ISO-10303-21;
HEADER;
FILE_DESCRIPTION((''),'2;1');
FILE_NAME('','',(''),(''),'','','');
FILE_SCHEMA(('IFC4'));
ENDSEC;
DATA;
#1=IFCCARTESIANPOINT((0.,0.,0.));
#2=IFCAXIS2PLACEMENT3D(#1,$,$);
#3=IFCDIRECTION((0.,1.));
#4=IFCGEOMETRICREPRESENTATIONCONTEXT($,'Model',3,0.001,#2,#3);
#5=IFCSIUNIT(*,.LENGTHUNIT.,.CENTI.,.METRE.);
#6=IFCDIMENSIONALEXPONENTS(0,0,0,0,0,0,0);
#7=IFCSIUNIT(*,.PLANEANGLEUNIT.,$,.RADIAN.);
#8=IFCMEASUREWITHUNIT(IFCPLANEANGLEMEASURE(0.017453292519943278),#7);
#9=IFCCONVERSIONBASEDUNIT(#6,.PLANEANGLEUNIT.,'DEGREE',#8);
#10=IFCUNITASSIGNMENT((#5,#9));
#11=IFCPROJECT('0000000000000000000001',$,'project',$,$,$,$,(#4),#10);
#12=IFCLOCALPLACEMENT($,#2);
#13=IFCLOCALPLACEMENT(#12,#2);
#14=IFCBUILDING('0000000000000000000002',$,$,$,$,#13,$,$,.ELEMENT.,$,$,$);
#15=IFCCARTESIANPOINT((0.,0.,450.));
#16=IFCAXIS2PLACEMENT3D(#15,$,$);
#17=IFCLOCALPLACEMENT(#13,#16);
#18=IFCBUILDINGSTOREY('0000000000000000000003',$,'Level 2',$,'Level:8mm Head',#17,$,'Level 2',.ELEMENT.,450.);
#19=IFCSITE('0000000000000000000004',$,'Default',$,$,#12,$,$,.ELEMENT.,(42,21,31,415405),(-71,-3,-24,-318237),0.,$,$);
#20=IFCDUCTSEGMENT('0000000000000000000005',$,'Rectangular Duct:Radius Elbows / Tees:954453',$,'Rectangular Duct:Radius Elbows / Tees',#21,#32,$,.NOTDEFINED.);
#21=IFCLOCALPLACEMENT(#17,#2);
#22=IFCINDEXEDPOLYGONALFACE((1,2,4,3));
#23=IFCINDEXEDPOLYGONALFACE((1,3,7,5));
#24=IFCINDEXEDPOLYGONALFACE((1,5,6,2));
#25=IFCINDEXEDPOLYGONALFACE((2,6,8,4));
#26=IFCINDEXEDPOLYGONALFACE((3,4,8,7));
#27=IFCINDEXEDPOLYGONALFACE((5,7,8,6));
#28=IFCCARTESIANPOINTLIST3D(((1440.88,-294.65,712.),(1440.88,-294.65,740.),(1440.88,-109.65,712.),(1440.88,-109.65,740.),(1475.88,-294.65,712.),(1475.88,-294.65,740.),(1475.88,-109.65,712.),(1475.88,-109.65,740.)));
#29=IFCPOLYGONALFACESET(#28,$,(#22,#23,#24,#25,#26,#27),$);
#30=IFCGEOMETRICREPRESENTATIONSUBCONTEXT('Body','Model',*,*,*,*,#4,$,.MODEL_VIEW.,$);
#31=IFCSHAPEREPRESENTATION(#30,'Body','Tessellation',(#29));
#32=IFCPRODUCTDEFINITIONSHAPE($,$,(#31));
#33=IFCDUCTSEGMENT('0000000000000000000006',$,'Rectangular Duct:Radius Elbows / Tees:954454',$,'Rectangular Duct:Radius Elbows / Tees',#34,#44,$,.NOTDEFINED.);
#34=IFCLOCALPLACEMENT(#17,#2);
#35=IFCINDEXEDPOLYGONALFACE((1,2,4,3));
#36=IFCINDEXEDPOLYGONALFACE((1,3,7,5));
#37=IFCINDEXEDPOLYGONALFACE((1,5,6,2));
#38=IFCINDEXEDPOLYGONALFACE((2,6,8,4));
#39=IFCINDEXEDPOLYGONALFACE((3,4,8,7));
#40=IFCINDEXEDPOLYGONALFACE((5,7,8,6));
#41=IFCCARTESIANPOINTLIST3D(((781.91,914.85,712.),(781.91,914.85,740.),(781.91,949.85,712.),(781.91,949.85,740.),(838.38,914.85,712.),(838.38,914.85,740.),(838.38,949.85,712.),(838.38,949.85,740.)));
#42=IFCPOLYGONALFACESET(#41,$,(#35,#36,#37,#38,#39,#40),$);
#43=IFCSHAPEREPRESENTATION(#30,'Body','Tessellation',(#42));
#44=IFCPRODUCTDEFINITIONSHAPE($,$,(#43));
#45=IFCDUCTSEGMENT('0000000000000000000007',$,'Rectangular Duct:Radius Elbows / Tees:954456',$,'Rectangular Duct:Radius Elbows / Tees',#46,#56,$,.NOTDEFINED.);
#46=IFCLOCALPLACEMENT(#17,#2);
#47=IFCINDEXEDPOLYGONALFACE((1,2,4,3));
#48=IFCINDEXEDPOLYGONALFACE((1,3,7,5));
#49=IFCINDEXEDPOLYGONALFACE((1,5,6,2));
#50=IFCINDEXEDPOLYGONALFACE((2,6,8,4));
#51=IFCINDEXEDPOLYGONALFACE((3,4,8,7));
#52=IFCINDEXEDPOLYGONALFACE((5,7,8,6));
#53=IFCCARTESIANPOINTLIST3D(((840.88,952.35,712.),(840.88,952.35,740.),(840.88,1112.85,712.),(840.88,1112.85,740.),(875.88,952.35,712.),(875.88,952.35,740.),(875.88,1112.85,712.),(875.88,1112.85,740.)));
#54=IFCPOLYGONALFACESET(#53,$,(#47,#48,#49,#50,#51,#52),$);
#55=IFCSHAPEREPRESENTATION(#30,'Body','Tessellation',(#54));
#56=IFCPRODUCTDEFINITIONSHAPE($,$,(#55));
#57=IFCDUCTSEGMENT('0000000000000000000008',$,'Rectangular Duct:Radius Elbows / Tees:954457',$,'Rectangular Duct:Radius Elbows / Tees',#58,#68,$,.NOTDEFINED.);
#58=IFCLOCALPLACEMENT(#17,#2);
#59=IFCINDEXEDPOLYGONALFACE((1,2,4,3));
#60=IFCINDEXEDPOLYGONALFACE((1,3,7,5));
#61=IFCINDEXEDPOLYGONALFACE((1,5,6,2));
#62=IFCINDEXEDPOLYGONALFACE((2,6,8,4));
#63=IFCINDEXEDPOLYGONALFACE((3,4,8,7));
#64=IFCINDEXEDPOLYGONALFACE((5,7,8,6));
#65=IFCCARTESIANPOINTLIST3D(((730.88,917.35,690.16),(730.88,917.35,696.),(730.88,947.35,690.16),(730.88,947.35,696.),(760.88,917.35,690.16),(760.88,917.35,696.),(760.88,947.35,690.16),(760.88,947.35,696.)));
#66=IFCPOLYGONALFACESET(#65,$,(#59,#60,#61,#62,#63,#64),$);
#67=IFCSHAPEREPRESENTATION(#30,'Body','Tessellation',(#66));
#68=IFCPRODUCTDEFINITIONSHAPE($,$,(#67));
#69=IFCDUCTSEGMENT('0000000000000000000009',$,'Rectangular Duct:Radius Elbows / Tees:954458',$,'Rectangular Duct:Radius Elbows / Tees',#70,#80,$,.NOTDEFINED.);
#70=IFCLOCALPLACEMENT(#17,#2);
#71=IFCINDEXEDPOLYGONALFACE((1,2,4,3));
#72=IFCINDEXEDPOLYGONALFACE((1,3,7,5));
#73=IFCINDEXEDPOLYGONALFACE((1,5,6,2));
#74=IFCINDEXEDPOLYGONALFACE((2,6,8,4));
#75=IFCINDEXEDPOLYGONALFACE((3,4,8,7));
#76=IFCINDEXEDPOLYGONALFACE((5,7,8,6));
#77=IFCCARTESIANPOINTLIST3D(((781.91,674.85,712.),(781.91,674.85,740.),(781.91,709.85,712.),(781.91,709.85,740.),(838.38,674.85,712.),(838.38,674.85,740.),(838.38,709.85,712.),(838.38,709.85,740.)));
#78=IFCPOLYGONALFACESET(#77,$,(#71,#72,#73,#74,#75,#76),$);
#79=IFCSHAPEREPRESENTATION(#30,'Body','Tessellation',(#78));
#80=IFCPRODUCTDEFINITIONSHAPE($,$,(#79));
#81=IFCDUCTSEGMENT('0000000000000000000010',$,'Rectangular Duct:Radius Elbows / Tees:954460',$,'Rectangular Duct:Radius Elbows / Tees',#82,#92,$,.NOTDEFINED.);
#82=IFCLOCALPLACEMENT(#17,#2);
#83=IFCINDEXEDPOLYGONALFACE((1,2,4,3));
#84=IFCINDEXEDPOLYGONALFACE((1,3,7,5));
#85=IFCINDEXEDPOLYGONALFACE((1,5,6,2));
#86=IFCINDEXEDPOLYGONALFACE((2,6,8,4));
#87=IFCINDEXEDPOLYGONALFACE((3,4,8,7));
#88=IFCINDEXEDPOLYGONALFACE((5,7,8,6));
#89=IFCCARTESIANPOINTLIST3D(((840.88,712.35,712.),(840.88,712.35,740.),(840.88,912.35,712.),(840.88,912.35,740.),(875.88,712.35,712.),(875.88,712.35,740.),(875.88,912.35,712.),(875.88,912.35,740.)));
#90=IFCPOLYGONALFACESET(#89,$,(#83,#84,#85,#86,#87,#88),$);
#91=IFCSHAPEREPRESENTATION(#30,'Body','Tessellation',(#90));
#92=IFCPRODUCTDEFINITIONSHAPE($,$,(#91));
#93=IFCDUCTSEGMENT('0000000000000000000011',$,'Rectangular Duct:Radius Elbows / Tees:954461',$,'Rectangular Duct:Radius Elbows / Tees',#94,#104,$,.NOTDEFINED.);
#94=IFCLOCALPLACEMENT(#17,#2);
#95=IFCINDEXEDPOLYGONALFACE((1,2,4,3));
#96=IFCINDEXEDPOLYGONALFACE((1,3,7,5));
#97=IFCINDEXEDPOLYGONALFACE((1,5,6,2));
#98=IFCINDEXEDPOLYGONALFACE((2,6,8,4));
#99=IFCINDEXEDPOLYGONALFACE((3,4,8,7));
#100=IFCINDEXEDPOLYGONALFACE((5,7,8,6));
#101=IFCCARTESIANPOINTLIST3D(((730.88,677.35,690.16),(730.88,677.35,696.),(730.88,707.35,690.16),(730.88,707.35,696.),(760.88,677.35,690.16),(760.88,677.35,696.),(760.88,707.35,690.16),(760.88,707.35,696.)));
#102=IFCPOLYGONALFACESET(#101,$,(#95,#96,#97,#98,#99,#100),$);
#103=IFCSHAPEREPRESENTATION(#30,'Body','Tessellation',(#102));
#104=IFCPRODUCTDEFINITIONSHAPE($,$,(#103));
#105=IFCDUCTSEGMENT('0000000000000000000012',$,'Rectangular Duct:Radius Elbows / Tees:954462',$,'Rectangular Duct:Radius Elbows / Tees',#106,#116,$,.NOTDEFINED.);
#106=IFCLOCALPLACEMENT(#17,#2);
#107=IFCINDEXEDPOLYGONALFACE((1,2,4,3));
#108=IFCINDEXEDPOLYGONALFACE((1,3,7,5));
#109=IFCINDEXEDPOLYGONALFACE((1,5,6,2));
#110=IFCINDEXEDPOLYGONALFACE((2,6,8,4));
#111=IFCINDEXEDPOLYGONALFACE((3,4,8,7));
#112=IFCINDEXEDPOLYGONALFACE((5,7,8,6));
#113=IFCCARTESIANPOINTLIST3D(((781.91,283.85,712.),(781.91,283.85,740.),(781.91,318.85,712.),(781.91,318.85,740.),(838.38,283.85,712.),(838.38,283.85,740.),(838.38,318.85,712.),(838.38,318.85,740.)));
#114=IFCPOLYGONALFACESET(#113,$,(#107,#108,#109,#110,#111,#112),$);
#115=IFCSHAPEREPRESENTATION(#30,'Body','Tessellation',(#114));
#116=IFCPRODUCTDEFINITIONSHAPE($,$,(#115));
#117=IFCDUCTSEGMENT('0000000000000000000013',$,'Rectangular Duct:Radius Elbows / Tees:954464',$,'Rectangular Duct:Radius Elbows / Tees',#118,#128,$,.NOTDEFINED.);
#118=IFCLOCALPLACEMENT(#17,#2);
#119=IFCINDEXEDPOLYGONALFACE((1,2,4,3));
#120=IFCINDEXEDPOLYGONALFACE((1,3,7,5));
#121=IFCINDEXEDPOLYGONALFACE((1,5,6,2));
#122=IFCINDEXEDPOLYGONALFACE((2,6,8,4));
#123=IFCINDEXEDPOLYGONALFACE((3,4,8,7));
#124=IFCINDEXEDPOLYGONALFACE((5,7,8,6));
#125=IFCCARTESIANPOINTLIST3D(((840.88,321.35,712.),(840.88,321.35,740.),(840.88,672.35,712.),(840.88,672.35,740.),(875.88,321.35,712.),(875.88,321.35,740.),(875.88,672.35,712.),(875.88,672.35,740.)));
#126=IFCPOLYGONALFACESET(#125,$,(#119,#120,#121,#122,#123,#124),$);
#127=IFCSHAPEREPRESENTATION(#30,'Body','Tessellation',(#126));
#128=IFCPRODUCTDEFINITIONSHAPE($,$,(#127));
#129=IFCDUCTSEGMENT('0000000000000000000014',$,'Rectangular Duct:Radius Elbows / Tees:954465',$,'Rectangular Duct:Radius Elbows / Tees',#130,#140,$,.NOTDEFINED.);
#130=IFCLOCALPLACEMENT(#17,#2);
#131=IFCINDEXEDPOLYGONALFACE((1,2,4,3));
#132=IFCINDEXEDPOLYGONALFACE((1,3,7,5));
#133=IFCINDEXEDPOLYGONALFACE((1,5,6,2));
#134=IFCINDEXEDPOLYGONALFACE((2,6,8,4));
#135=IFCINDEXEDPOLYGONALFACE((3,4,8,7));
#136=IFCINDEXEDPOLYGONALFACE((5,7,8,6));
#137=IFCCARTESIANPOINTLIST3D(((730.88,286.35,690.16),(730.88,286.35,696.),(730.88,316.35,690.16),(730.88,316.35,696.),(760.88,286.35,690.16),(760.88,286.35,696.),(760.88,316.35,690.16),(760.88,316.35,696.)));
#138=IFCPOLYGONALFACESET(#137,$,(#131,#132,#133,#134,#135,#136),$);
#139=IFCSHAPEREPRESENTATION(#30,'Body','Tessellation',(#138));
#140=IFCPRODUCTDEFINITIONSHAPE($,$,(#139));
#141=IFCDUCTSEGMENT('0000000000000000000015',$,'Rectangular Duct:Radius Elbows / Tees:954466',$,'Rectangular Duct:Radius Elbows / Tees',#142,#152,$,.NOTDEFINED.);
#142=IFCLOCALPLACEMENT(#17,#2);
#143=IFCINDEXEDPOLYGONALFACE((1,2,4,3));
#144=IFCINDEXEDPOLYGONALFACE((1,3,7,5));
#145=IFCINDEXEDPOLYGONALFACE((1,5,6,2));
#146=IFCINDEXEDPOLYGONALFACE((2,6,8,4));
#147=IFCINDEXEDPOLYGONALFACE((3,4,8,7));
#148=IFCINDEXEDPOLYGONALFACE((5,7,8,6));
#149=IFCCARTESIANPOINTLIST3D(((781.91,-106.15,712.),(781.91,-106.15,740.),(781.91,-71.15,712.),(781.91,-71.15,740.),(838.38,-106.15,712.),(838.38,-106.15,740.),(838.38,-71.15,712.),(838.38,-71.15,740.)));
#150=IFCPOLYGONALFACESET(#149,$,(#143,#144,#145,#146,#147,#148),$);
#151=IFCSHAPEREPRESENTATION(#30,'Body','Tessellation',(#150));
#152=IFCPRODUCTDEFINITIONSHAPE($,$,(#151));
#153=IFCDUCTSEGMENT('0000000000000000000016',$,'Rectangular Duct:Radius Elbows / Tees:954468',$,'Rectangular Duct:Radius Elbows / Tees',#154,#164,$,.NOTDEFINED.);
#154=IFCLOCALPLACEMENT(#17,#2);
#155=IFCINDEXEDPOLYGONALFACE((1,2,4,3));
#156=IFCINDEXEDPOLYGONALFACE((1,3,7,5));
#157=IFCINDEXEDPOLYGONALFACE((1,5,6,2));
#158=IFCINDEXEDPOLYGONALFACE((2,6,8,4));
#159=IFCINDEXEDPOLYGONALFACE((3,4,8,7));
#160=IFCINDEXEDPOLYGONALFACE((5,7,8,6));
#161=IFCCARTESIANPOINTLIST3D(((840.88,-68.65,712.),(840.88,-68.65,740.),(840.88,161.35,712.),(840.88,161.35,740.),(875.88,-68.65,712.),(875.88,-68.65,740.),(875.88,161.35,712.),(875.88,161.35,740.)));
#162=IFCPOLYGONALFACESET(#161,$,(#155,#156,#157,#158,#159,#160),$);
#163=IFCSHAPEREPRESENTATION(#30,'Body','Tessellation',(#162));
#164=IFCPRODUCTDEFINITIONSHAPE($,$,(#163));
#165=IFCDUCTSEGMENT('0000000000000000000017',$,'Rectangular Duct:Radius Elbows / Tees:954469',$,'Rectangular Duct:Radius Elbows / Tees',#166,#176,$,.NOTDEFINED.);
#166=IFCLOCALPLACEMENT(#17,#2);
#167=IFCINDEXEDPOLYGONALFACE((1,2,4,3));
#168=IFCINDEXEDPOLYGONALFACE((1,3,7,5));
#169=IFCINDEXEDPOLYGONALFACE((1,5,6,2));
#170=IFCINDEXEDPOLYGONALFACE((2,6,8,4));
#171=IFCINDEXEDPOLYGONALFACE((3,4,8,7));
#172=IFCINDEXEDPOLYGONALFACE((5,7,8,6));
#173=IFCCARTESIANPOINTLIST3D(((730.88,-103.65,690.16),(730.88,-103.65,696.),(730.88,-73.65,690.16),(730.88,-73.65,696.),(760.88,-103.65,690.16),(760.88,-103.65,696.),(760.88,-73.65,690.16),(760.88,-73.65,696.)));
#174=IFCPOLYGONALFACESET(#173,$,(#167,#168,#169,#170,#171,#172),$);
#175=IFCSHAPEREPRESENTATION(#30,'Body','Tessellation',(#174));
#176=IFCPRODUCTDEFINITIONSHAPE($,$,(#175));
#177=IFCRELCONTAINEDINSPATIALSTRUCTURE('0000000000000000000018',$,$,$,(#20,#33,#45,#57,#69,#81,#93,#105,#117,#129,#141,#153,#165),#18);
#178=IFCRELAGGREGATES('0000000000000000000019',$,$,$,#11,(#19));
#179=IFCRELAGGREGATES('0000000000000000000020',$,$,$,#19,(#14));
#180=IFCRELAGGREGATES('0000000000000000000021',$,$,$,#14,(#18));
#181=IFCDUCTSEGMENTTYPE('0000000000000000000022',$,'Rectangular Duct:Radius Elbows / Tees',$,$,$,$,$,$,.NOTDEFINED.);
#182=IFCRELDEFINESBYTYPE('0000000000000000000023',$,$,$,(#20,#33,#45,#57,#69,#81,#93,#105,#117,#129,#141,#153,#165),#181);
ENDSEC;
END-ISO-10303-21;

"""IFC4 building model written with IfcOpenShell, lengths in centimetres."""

from ifc_helpers import new_model, entity, si_unit, converted_unit, direction, frame, origin, place, context, subcontext, project, spatial, indexed_curve, outline, extrude, type_object, element, save


model = new_model("IFC4")

# Units and contexts
model_context = context("Model", 3, precision=0.001, world=origin(), true_north=direction((0.0, 1.0)))
body_context = subcontext(model_context, "Body", "Model", "MODEL_VIEW")
ifc_project = project(units=[si_unit("LENGTHUNIT", "METRE", prefix="CENTI"), converted_unit("PLANEANGLEUNIT", "DEGREE", entity("IfcPlaneAngleMeasure", 0.017453292519943278), si_unit("PLANEANGLEUNIT", "RADIAN"), dimensions=[0, 0, 0, 0, 0, 0, 0])], contexts=[model_context])

# Site, building, storey
site_placement = place(None, origin())
site = spatial("IfcSite", under=ifc_project, at=site_placement, Name="Default", CompositionType="ELEMENT", RefLatitude=(42, 21, 31, 415405), RefLongitude=(-71, -3, -24, -318237), RefElevation=0.0)
building_placement = place(site_placement, origin())
building = spatial("IfcBuilding", under=site, at=building_placement, CompositionType="ELEMENT")
storey_placement = place(building_placement, frame((0.0, 0.0, 450.0)))
storey = spatial("IfcBuildingStorey", under=building, at=storey_placement, Name="Level 2", ObjectType="Level:8mm Head", LongName="Level 2", CompositionType="ELEMENT", Elevation=450.0)

# Duct segments
duct_segment_type = type_object("IfcDuctSegmentType", Name="Rectangular Duct:Radius Elbows / Tees", PredefinedType="NOTDEFINED")
duct_segment_1_placement = place(storey_placement, origin())
element("IfcDuctSegment", 1, at=duct_segment_1_placement, inside=storey, type_object=duct_segment_type, Name="Rectangular Duct:Radius Elbows / Tees:954453", ObjectType="Rectangular Duct:Radius Elbows / Tees", PredefinedType="NOTDEFINED", context=body_context, shape_type="SweptSolid", body=[
    extrude(outline(indexed_curve([(-92.5, -17.5), (92.5, -17.5), (92.5, 17.5), (-92.5, 17.5), (-92.5, -17.5)], self_intersect=False)), frame((1458.38, -202.15, 712.0), z_axis=(0.0, 0.0, 1.0), x_axis=(0.0, -1.0, 0.0)), (0.0, 0.0, 1.0), 28.0),
])
duct_segment_2_placement = place(storey_placement, origin())
element("IfcDuctSegment", 2, at=duct_segment_2_placement, inside=storey, type_object=duct_segment_type, Name="Rectangular Duct:Radius Elbows / Tees:954454", ObjectType="Rectangular Duct:Radius Elbows / Tees", PredefinedType="NOTDEFINED", context=body_context, shape_type="SweptSolid", body=[
    extrude(outline(indexed_curve([(-28.23, -17.5), (28.23, -17.5), (28.23, 17.5), (-28.23, 17.5), (-28.23, -17.5)], self_intersect=False)), frame((810.14, 932.35, 712.0)), (0.0, 0.0, 1.0), 28.0),
])
duct_segment_3_placement = place(storey_placement, origin())
element("IfcDuctSegment", 3, at=duct_segment_3_placement, inside=storey, type_object=duct_segment_type, Name="Rectangular Duct:Radius Elbows / Tees:954456", ObjectType="Rectangular Duct:Radius Elbows / Tees", PredefinedType="NOTDEFINED", context=body_context, shape_type="SweptSolid", body=[
    extrude(outline(indexed_curve([(-80.25, -17.5), (80.25, -17.5), (80.25, 17.5), (-80.25, 17.5), (-80.25, -17.5)], self_intersect=False)), frame((858.38, 1032.6, 712.0), z_axis=(0.0, 0.0, 1.0), x_axis=(0.0, -1.0, 0.0)), (0.0, 0.0, 1.0), 28.0),
])
duct_segment_4_placement = place(storey_placement, origin())
element("IfcDuctSegment", 4, at=duct_segment_4_placement, inside=storey, type_object=duct_segment_type, Name="Rectangular Duct:Radius Elbows / Tees:954457", ObjectType="Rectangular Duct:Radius Elbows / Tees", PredefinedType="NOTDEFINED", context=body_context, shape_type="SweptSolid", body=[
    extrude(outline(indexed_curve([(-15.0, -15.0), (15.0, -15.0), (15.0, 15.0), (-15.0, 15.0), (-15.0, -15.0)], self_intersect=False)), frame((745.88, 932.35, 690.16)), (0.0, 0.0, 1.0), 5.84),
])
duct_segment_5_placement = place(storey_placement, origin())
element("IfcDuctSegment", 5, at=duct_segment_5_placement, inside=storey, type_object=duct_segment_type, Name="Rectangular Duct:Radius Elbows / Tees:954458", ObjectType="Rectangular Duct:Radius Elbows / Tees", PredefinedType="NOTDEFINED", context=body_context, shape_type="SweptSolid", body=[
    extrude(outline(indexed_curve([(-28.23, -17.5), (28.23, -17.5), (28.23, 17.5), (-28.23, 17.5), (-28.23, -17.5)], self_intersect=False)), frame((810.14, 692.35, 712.0)), (0.0, 0.0, 1.0), 28.0),
])
duct_segment_6_placement = place(storey_placement, origin())
element("IfcDuctSegment", 6, at=duct_segment_6_placement, inside=storey, type_object=duct_segment_type, Name="Rectangular Duct:Radius Elbows / Tees:954460", ObjectType="Rectangular Duct:Radius Elbows / Tees", PredefinedType="NOTDEFINED", context=body_context, shape_type="SweptSolid", body=[
    extrude(outline(indexed_curve([(-100.0, -17.5), (100.0, -17.5), (100.0, 17.5), (-100.0, 17.5), (-100.0, -17.5)], self_intersect=False)), frame((858.38, 812.35, 712.0), z_axis=(0.0, 0.0, 1.0), x_axis=(0.0, -1.0, 0.0)), (0.0, 0.0, 1.0), 28.0),
])
duct_segment_7_placement = place(storey_placement, origin())
element("IfcDuctSegment", 7, at=duct_segment_7_placement, inside=storey, type_object=duct_segment_type, Name="Rectangular Duct:Radius Elbows / Tees:954461", ObjectType="Rectangular Duct:Radius Elbows / Tees", PredefinedType="NOTDEFINED", context=body_context, shape_type="SweptSolid", body=[
    extrude(outline(indexed_curve([(-15.0, -15.0), (15.0, -15.0), (15.0, 15.0), (-15.0, 15.0), (-15.0, -15.0)], self_intersect=False)), frame((745.88, 692.35, 690.16)), (0.0, 0.0, 1.0), 5.84),
])
duct_segment_8_placement = place(storey_placement, origin())
element("IfcDuctSegment", 8, at=duct_segment_8_placement, inside=storey, type_object=duct_segment_type, Name="Rectangular Duct:Radius Elbows / Tees:954462", ObjectType="Rectangular Duct:Radius Elbows / Tees", PredefinedType="NOTDEFINED", context=body_context, shape_type="SweptSolid", body=[
    extrude(outline(indexed_curve([(-28.23, -17.5), (28.23, -17.5), (28.23, 17.5), (-28.23, 17.5), (-28.23, -17.5)], self_intersect=False)), frame((810.14, 301.35, 712.0), z_axis=(0.0, 0.0, 1.0), x_axis=(-1.0, 0.0, 0.0)), (0.0, 0.0, 1.0), 28.0),
])
duct_segment_9_placement = place(storey_placement, origin())
element("IfcDuctSegment", 9, at=duct_segment_9_placement, inside=storey, type_object=duct_segment_type, Name="Rectangular Duct:Radius Elbows / Tees:954464", ObjectType="Rectangular Duct:Radius Elbows / Tees", PredefinedType="NOTDEFINED", context=body_context, shape_type="SweptSolid", body=[
    extrude(outline(indexed_curve([(-175.5, -17.5), (175.5, -17.5), (175.5, 17.5), (-175.5, 17.5), (-175.5, -17.5)], self_intersect=False)), frame((858.38, 496.85, 712.0), z_axis=(0.0, 0.0, 1.0), x_axis=(0.0, -1.0, 0.0)), (0.0, 0.0, 1.0), 28.0),
])
duct_segment_10_placement = place(storey_placement, origin())
element("IfcDuctSegment", 10, at=duct_segment_10_placement, inside=storey, type_object=duct_segment_type, Name="Rectangular Duct:Radius Elbows / Tees:954465", ObjectType="Rectangular Duct:Radius Elbows / Tees", PredefinedType="NOTDEFINED", context=body_context, shape_type="SweptSolid", body=[
    extrude(outline(indexed_curve([(-15.0, -15.0), (15.0, -15.0), (15.0, 15.0), (-15.0, 15.0), (-15.0, -15.0)], self_intersect=False)), frame((745.88, 301.35, 690.16)), (0.0, 0.0, 1.0), 5.84),
])
duct_segment_11_placement = place(storey_placement, origin())
element("IfcDuctSegment", 11, at=duct_segment_11_placement, inside=storey, type_object=duct_segment_type, Name="Rectangular Duct:Radius Elbows / Tees:954466", ObjectType="Rectangular Duct:Radius Elbows / Tees", PredefinedType="NOTDEFINED", context=body_context, shape_type="SweptSolid", body=[
    extrude(outline(indexed_curve([(-28.23, -17.5), (28.23, -17.5), (28.23, 17.5), (-28.23, 17.5), (-28.23, -17.5)], self_intersect=False)), frame((810.14, -88.65, 712.0)), (0.0, 0.0, 1.0), 28.0),
])
duct_segment_12_placement = place(storey_placement, origin())
element("IfcDuctSegment", 12, at=duct_segment_12_placement, inside=storey, type_object=duct_segment_type, Name="Rectangular Duct:Radius Elbows / Tees:954468", ObjectType="Rectangular Duct:Radius Elbows / Tees", PredefinedType="NOTDEFINED", context=body_context, shape_type="SweptSolid", body=[
    extrude(outline(indexed_curve([(-115.0, -17.5), (115.0, -17.5), (115.0, 17.5), (-115.0, 17.5), (-115.0, -17.5)], self_intersect=False)), frame((858.38, 46.35, 712.0), z_axis=(0.0, 0.0, 1.0), x_axis=(0.0, -1.0, 0.0)), (0.0, 0.0, 1.0), 28.0),
])
duct_segment_13_placement = place(storey_placement, origin())
element("IfcDuctSegment", 13, at=duct_segment_13_placement, inside=storey, type_object=duct_segment_type, Name="Rectangular Duct:Radius Elbows / Tees:954469", ObjectType="Rectangular Duct:Radius Elbows / Tees", PredefinedType="NOTDEFINED", context=body_context, shape_type="SweptSolid", body=[
    extrude(outline(indexed_curve([(-15.0, -15.0), (15.0, -15.0), (15.0, 15.0), (-15.0, 15.0), (-15.0, -15.0)], self_intersect=False)), frame((745.88, -88.65, 690.16)), (0.0, 0.0, 1.0), 5.84),
])

save(model, "model.ifc")
